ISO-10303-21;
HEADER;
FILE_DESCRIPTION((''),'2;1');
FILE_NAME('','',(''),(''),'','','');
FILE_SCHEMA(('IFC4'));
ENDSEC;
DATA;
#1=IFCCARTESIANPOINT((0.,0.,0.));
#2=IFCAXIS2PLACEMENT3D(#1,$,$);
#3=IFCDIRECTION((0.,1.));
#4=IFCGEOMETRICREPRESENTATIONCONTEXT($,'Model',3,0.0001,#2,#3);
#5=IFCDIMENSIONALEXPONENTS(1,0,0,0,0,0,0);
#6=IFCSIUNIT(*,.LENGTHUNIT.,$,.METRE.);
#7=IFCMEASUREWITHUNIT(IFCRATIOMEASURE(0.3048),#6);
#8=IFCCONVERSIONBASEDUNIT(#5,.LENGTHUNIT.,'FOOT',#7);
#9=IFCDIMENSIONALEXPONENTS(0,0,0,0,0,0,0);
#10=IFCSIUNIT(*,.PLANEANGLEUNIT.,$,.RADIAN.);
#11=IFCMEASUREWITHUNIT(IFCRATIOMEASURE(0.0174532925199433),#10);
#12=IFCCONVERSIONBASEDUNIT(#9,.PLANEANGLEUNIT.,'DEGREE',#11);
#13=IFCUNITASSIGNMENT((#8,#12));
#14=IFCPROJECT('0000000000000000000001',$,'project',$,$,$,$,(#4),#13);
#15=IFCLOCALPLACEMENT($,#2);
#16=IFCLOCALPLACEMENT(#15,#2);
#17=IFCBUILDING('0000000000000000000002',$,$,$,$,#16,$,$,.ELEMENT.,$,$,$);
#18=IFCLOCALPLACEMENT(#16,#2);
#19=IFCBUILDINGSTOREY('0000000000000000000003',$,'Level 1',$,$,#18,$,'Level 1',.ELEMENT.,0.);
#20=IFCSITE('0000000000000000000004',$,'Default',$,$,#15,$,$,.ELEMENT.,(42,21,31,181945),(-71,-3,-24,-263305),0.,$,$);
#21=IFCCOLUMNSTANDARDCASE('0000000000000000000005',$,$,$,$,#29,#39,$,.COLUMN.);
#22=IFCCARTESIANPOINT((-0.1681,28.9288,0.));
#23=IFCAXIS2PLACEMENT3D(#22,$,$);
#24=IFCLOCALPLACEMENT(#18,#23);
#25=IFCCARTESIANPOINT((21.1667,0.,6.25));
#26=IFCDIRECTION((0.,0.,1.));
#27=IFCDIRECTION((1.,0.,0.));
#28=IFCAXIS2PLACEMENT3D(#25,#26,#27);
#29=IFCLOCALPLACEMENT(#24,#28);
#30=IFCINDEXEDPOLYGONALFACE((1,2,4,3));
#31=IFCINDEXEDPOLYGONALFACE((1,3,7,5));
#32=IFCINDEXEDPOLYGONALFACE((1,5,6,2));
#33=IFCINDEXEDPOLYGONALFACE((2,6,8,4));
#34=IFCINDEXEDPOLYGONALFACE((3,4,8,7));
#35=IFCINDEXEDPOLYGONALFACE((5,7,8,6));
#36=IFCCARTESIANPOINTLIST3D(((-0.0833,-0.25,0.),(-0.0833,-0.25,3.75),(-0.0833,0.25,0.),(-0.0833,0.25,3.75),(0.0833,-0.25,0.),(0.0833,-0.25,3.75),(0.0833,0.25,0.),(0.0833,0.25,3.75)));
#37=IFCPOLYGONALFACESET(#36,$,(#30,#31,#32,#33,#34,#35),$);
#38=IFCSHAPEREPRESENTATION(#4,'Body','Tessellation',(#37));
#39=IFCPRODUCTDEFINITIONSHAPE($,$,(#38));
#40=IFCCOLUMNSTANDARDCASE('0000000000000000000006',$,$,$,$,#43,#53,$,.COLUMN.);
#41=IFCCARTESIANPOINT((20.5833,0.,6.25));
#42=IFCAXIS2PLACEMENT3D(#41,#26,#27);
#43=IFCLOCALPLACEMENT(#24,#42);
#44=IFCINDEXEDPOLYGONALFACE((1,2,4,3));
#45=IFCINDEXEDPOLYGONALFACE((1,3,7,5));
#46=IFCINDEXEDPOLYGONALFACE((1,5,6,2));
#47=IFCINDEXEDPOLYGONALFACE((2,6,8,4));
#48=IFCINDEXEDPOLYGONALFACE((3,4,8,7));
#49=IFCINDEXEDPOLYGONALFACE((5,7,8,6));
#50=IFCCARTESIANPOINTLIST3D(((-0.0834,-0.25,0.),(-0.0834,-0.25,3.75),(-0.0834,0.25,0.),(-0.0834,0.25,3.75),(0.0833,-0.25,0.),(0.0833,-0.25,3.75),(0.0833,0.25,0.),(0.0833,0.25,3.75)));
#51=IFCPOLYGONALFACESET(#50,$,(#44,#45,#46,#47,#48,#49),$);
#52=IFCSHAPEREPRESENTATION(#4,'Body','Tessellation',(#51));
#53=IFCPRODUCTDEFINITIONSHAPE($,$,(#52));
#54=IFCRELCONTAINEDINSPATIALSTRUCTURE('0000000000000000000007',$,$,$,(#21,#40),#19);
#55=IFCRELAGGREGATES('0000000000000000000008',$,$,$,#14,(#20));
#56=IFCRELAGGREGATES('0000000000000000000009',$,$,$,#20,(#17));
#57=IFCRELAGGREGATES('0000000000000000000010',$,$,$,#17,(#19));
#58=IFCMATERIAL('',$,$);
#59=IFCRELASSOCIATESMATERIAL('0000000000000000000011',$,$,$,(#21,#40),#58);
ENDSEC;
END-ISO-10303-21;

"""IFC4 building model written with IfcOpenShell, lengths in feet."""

from ifc_helpers import new_model, entity, si_unit, converted_unit, direction, frame, origin, place, context, project, spatial, rectangle, extrude, material, element, save


model = new_model("IFC4")

# Units and contexts
model_context = context("Model", 3, precision=0.0001, world=origin(), true_north=direction((0.0, 1.0)))
ifc_project = project(units=[converted_unit("LENGTHUNIT", "FOOT", entity("IfcRatioMeasure", 0.3048), si_unit("LENGTHUNIT", "METRE"), dimensions=[1, 0, 0, 0, 0, 0, 0]), converted_unit("PLANEANGLEUNIT", "DEGREE", entity("IfcRatioMeasure", 0.0174532925199433), si_unit("PLANEANGLEUNIT", "RADIAN"), dimensions=[0, 0, 0, 0, 0, 0, 0])], contexts=[model_context])

# Site, building, storey
site_placement = place(None, origin())
site = spatial("IfcSite", under=ifc_project, at=site_placement, Name="Default", CompositionType="ELEMENT", RefLatitude=(42, 21, 31, 181945), RefLongitude=(-71, -3, -24, -263305), RefElevation=0.0)
building_placement = place(site_placement, origin())
building = spatial("IfcBuilding", under=site, at=building_placement, CompositionType="ELEMENT")
storey_placement = place(building_placement, origin())
storey = spatial("IfcBuildingStorey", under=building, at=storey_placement, Name="Level 1", LongName="Level 1", CompositionType="ELEMENT", Elevation=0.0)

# Columns
ifc_material_1 = material(Name="")
placement = place(storey_placement, frame((-0.1681, 28.9288, 0.0)))
for number, where, z_axis, x_axis in (
    (1, (21.1667, 0.0, 6.25), (0.0, 0.0, 1.0), (1.0, 0.0, 0.0)),
    (2, (20.5833, 0.0, 6.25), (0.0, 0.0, 1.0), (1.0, 0.0, 0.0)),
):
    element("IfcColumnStandardCase", number, at=place(placement, frame(where, z_axis=z_axis, x_axis=x_axis)), inside=storey, material=ifc_material_1, PredefinedType="COLUMN", context=model_context, shape_type="SweptSolid", body=[
        extrude(rectangle(XDim=0.1667, YDim=0.5), origin(), (0.0, 0.0, 1.0), 3.75),
    ])

save(model, "model.ifc")
